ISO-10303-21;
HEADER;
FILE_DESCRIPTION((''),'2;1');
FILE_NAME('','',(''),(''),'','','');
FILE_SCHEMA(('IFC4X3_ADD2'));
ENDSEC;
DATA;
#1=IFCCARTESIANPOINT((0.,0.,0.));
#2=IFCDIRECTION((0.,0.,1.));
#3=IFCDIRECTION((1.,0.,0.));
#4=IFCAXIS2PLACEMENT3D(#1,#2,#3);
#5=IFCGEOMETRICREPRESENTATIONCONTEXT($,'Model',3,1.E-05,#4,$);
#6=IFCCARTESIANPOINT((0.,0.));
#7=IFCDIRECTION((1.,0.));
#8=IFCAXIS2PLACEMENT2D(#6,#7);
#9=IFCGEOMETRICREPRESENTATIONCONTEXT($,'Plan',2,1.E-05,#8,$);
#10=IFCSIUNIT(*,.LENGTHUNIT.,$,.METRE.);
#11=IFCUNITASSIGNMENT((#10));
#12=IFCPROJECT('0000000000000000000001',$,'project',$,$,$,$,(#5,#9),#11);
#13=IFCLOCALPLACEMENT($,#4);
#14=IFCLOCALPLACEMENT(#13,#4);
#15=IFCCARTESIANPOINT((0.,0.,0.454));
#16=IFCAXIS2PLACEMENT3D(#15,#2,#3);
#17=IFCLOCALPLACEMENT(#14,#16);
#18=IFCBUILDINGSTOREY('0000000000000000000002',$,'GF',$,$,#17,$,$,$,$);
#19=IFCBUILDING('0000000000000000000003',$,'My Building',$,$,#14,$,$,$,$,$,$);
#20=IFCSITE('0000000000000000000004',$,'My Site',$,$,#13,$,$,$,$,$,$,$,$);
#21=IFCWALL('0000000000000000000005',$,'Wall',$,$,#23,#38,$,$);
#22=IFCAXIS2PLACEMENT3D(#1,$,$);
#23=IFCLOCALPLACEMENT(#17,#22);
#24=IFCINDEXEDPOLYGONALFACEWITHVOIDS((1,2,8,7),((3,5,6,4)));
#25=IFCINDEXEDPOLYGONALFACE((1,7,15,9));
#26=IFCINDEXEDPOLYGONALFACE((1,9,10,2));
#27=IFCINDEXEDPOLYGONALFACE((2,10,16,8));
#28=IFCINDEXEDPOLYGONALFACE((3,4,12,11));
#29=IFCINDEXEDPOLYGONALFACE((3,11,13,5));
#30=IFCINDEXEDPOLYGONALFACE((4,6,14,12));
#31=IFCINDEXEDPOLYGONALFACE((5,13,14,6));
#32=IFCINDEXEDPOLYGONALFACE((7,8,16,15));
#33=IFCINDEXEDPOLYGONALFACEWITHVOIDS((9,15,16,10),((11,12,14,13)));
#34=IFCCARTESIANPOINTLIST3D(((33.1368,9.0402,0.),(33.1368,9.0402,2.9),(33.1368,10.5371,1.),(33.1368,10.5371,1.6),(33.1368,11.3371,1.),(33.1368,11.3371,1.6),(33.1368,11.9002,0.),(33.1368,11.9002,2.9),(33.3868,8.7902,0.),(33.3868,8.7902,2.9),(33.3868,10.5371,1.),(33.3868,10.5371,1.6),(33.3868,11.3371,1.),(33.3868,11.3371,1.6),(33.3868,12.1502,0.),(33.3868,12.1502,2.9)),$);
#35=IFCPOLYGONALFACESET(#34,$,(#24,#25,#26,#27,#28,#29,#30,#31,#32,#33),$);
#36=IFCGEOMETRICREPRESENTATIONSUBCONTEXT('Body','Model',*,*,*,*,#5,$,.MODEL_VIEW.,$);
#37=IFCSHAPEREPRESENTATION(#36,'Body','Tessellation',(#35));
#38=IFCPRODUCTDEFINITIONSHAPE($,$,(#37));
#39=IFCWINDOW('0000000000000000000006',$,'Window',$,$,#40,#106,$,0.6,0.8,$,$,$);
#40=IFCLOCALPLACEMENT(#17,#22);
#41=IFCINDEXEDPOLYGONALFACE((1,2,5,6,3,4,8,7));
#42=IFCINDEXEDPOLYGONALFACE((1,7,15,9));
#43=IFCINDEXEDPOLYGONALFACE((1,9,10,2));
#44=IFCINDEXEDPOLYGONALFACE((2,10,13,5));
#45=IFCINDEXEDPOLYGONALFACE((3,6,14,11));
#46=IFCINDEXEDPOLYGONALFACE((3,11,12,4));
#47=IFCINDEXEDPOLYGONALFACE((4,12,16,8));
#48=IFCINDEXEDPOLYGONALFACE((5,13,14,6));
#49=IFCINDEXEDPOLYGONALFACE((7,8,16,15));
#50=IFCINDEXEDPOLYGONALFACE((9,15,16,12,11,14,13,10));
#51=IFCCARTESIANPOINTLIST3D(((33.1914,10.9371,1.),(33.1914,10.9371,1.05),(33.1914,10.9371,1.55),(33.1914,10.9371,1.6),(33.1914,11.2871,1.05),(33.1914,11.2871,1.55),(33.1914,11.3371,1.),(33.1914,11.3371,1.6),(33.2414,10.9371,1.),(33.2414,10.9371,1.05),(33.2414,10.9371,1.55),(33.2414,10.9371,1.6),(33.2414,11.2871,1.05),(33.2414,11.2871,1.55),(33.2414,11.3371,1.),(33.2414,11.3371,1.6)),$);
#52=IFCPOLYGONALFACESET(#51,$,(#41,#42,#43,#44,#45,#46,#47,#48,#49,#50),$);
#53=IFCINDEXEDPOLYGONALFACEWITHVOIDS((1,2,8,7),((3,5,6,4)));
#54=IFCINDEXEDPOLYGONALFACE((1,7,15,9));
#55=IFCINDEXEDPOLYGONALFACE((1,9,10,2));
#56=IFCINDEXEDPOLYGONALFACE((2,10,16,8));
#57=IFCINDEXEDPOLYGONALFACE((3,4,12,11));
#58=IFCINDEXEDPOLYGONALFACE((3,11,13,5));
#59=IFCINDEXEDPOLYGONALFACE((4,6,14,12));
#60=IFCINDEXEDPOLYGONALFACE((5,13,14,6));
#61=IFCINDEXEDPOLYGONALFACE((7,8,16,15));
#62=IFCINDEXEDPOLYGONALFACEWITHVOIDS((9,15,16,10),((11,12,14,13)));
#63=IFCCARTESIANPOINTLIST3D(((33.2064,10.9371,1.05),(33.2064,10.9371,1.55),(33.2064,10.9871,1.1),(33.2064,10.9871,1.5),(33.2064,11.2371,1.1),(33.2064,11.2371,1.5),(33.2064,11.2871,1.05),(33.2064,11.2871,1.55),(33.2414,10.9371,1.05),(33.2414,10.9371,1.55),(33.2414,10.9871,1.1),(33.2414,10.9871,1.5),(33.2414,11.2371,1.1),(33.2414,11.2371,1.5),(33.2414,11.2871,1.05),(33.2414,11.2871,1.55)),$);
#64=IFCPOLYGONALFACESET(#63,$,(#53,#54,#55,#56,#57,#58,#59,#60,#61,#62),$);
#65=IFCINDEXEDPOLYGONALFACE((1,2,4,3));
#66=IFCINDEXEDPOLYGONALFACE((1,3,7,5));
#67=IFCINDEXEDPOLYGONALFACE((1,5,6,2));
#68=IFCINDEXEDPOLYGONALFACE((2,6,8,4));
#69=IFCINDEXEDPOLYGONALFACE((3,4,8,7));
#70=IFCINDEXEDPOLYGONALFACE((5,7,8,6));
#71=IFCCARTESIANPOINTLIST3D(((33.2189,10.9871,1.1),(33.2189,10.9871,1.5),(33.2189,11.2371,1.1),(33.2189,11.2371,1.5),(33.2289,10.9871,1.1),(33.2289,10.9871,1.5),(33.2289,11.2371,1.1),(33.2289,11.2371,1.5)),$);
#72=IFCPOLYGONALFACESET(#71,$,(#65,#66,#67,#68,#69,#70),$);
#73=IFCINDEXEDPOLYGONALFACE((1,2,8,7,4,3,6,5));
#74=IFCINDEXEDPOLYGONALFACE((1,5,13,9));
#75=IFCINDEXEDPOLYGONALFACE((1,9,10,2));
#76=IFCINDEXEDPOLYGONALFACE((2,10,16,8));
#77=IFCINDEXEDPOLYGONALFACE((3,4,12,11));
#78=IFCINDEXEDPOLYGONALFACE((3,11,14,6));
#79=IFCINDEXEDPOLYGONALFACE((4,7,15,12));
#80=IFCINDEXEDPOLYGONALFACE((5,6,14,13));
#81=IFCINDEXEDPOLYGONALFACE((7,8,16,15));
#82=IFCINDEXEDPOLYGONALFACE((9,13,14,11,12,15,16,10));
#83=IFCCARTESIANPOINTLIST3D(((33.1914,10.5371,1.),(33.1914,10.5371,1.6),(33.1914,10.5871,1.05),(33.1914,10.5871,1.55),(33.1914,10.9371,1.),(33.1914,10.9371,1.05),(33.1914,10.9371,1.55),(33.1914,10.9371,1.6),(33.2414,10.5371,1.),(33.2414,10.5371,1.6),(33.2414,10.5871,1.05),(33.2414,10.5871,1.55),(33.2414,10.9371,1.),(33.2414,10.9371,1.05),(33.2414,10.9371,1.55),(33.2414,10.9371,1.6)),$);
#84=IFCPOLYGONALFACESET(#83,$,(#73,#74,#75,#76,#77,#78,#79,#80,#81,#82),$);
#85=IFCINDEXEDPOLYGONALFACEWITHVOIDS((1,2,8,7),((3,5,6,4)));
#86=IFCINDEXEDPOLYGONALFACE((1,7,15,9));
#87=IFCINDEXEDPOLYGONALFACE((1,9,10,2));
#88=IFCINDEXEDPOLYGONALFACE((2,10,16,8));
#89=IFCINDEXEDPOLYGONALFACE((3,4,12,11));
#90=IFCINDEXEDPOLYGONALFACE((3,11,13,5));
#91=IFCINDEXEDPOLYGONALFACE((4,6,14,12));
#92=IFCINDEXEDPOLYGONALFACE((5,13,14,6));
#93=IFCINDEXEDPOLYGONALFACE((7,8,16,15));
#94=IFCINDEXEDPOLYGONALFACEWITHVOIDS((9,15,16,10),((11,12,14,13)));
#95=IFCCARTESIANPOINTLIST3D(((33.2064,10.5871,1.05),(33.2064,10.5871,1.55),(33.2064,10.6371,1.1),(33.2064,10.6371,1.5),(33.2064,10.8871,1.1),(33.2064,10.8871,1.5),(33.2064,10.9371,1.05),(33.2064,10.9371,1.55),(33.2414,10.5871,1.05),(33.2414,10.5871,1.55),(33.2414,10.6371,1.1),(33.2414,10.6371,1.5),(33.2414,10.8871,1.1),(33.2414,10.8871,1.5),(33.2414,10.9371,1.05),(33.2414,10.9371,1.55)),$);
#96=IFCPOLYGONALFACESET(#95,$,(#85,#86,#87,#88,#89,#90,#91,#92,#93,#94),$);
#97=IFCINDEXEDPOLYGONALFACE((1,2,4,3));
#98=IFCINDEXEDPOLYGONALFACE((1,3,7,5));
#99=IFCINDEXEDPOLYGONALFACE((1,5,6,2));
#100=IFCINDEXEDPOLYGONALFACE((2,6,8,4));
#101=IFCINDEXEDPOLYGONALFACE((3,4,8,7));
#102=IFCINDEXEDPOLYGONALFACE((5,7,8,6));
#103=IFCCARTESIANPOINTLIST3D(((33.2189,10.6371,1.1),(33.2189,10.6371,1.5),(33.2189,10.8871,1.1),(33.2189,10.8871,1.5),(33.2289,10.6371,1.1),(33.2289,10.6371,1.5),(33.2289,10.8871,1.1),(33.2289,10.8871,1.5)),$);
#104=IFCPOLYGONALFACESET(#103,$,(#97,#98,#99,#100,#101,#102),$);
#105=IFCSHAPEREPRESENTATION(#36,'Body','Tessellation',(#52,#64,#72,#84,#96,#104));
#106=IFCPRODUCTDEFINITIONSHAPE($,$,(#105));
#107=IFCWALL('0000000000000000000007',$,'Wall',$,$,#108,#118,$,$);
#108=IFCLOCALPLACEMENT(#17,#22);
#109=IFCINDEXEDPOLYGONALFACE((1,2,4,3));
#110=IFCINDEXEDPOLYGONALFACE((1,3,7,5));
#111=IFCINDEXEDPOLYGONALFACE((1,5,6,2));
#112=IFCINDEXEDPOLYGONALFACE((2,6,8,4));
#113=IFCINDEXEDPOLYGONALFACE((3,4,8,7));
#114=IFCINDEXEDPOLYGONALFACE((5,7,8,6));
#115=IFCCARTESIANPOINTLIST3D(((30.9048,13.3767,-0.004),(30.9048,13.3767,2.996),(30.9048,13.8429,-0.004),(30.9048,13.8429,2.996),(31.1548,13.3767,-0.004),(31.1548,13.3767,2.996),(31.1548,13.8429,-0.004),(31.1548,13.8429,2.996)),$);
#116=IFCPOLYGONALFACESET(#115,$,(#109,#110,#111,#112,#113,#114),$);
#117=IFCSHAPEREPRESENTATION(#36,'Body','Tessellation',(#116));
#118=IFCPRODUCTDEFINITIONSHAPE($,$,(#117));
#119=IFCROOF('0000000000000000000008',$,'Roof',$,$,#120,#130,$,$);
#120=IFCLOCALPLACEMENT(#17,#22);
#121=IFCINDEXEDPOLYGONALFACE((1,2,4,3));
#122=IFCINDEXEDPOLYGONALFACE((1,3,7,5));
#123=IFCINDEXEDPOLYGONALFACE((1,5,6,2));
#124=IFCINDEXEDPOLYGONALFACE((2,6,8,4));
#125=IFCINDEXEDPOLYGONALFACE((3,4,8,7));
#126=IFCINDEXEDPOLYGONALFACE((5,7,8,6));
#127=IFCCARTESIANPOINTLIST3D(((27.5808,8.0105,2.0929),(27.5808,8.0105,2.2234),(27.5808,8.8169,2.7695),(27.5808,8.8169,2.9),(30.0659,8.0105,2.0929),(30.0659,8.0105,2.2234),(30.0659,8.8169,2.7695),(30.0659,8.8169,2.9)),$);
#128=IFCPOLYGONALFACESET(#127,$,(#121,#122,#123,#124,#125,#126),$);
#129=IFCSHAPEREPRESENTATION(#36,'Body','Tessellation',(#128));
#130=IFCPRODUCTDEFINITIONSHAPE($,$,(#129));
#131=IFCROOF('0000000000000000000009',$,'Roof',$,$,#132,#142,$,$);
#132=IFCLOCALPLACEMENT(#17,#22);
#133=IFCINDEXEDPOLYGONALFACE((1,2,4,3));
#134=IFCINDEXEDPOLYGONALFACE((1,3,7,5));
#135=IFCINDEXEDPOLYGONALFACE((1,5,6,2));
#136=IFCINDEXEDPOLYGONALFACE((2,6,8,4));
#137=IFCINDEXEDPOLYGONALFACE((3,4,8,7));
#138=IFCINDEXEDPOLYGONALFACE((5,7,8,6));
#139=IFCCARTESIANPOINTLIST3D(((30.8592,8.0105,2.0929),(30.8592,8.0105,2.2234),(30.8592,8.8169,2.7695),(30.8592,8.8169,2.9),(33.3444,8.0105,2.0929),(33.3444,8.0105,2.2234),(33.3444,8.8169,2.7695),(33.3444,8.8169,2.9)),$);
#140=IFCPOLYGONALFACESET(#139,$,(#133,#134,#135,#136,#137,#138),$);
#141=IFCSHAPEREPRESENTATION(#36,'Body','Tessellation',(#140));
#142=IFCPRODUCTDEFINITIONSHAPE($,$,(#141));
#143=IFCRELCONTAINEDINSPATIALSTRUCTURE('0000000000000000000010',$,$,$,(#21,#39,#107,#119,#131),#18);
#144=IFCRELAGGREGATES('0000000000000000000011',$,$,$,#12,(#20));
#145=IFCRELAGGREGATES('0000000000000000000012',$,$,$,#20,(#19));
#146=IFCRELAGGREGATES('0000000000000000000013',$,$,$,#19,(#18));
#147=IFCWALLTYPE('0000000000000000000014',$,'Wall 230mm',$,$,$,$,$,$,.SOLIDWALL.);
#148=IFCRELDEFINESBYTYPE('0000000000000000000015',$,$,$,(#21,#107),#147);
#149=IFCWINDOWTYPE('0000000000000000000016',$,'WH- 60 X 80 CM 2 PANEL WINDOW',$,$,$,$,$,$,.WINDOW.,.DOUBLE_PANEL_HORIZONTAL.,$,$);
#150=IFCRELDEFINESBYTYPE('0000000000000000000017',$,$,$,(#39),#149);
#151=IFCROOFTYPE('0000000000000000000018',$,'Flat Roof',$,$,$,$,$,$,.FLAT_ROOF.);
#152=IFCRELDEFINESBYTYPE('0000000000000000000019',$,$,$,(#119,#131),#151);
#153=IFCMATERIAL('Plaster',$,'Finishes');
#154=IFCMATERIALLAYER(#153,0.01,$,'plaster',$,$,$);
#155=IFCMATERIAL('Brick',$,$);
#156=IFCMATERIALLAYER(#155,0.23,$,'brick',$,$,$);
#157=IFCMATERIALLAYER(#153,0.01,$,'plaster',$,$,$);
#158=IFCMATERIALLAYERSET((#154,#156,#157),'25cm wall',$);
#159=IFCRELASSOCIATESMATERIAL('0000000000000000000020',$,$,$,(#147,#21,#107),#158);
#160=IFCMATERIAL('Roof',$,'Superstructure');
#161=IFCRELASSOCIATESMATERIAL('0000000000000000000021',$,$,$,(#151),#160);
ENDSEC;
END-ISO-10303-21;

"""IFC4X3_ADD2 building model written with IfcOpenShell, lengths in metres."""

from ifc_helpers import new_model, entity, si_unit, frame, origin_with_axes, origin_2d_with_axis, place, context, subcontext, project, spatial, polyline, line, indexed_curve, outline, extrude, shape, source, transform, mapped, material, layer, layer_set, layer_usage, type_object, type_shapes, element, fill, save


model = new_model("IFC4X3_ADD2")

# Units and contexts
model_context = context("Model", 3, precision=1e-05, world=origin_with_axes())
plan_context = context("Plan", 2, precision=1e-05, world=origin_2d_with_axis())
body_context_1 = subcontext(model_context, "Body", "Model", "MODEL_VIEW")
body_context_2 = subcontext(plan_context, "Body", "Plan", "PLAN_VIEW")
ifc_project = project(units=[si_unit("LENGTHUNIT", "METRE")], contexts=[model_context, plan_context])

# Site, building, storey
site_placement = place(None, origin_with_axes())
site = spatial("IfcSite", under=ifc_project, at=site_placement, Name="My Site")
building_placement = place(site_placement, origin_with_axes())
building = spatial("IfcBuilding", under=site, at=building_placement, Name="My Building")
storey_placement = place(building_placement, frame((0.0, 0.0, 0.454), z_axis=(0.0, 0.0, 1.0), x_axis=(1.0, 0.0, 0.0)))
storey = spatial("IfcBuildingStorey", under=building, at=storey_placement, Name="GF")

# Shared definitions
ifc_material_1 = material(Name="Plaster", Category="Finishes")
ifc_layer_1 = layer(ifc_material_1, 0.01, Name="plaster")
ifc_material_2 = material(Name="Brick")
ifc_layer_2 = layer(ifc_material_2, 0.23, Name="brick")
ifc_layer_3 = layer(ifc_material_1, 0.01, Name="plaster")
ifc_layer_set_1 = layer_set([ifc_layer_1, ifc_layer_2, ifc_layer_3], Name="25cm wall")
wall_type_1 = type_object("IfcWallType", Name="Wall 230mm", PredefinedType="SOLIDWALL", material=ifc_layer_set_1)

# Wall, opening, window
ifc_layer_usage_1 = layer_usage(ifc_layer_set_1, "AXIS2", "POSITIVE", 0.0)
wall_1_placement = place(storey_placement, frame((33.3868, 8.7902, 0.0), z_axis=(0.0, 0.0, 1.0), x_axis=(0.000001, 1.0, 0.0)))
wall_1 = element("IfcWall", 1, at=wall_1_placement, inside=storey, type_object=wall_type_1, material=ifc_layer_usage_1, Name="Wall", context=body_context_1, shape_type="SweptSolid", body=[
    extrude(outline(indexed_curve([(0.0, 0.0), (0.25, 0.25), (3.11, 0.25), (3.36, 0.0)], segments=[line(1, 2, 3, 4, 1)])), origin_with_axes(), (0.0, 0.0, 1.0), 2.9),
])
shared_shape_1 = source(origin_with_axes(), body_context_1, "Body", "SweptSolid", [
    extrude(outline(indexed_curve([(0.0, 0.0), (0.8, 0.0), (0.8, 0.6), (0.0, 0.6)], segments=[line(1, 2, 3, 4, 1)])), frame((0.0, -0.6, 0.0), z_axis=(0.0, -1.0, 0.0), x_axis=(1.0, 0.0, 0.0)), (0.0, 0.0, -1.0), 1.2),
])
opening_1_placement = place(wall_1_placement, frame((2.5469, 0.1953, 1.0), z_axis=(0.0, 0.0, 1.0), x_axis=(-1.0, 0.0, 0.0)))
opening_1 = element("IfcOpeningElement", 2, at=opening_1_placement, cuts=wall_1, PredefinedType="OPENING", context=body_context_1, shape_type="MappedRepresentation", body=[
    mapped(shared_shape_1, transform((0.0, 0.0, 0.0), x_axis=(1.0, 0.0, 0.0), y_axis=(0.0, 1.0, 0.0), z_axis=(0.0, 0.0, 1.0), scale=1.0)),
])
window_type = type_object("IfcWindowType", Name="WH- 60 X 80 CM 2 PANEL WINDOW", PartitioningType="DOUBLE_PANEL_HORIZONTAL", PredefinedType="WINDOW")
shared_shape_2 = source(origin_with_axes(), body_context_1, "Body", "SweptSolid", [
    extrude(outline(indexed_curve([(0.4, 0.0), (0.0, 0.0), (0.0, 0.6), (0.4, 0.6), (0.4, 0.55), (0.05, 0.55), (0.05, 0.05), (0.4, 0.05)], segments=[line(1, 2, 3, 4, 5, 6, 7, 8, 1)])), frame((0.0, 0.0, 0.0), z_axis=(0.0, -1.0, 0.0), x_axis=(1.0, 0.0, 0.0)), (0.0, 0.0, -1.0), 0.05),
    extrude(outline(indexed_curve([(0.0, 0.0), (0.35, 0.0), (0.35, 0.5), (0.0, 0.5)], segments=[line(1, 2, 3, 4, 1)]), holes=[indexed_curve([(0.05, 0.05), (0.3, 0.05), (0.3, 0.45), (0.05, 0.45)], segments=[line(1, 2, 3, 4, 1)])]), frame((0.05, 0.015, 0.05), z_axis=(0.0, -1.0, 0.0), x_axis=(1.0, 0.0, 0.0)), (0.0, 0.0, -1.0), 0.035),
    extrude(outline(indexed_curve([(0.05, 0.05), (0.3, 0.05), (0.3, 0.45), (0.05, 0.45)], segments=[line(1, 2, 3, 4, 1)])), frame((0.05, 0.0275, 0.05), z_axis=(0.0, -1.0, 0.0), x_axis=(1.0, 0.0, 0.0)), (0.0, 0.0, -1.0), 0.01),
    extrude(outline(indexed_curve([(0.0, 0.6), (0.4, 0.6), (0.4, 0.0), (0.0, 0.0), (0.0, 0.05), (0.35, 0.05), (0.35, 0.55), (0.0, 0.55)], segments=[line(1, 2, 3, 4, 5, 6, 7, 8, 1)])), frame((0.4, 0.0, 0.0), z_axis=(0.0, -1.0, 0.0), x_axis=(1.0, 0.0, 0.0)), (0.0, 0.0, -1.0), 0.05),
    extrude(outline(indexed_curve([(0.0, 0.0), (0.35, 0.0), (0.35, 0.5), (0.0, 0.5)], segments=[line(1, 2, 3, 4, 1)]), holes=[indexed_curve([(0.05, 0.05), (0.3, 0.05), (0.3, 0.45), (0.05, 0.45)], segments=[line(1, 2, 3, 4, 1)])]), frame((0.4, 0.015, 0.05), z_axis=(0.0, -1.0, 0.0), x_axis=(1.0, 0.0, 0.0)), (0.0, 0.0, -1.0), 0.035),
    extrude(outline(indexed_curve([(0.05, 0.05), (0.3, 0.05), (0.3, 0.45), (0.05, 0.45)], segments=[line(1, 2, 3, 4, 1)])), frame((0.4, 0.0275, 0.05), z_axis=(0.0, -1.0, 0.0), x_axis=(1.0, 0.0, 0.0)), (0.0, 0.0, -1.0), 0.01),
])
shared_shape_3 = source(origin_with_axes(), body_context_2, "Body", "Curve2D", [
    entity("IfcIndexedPolyCurve", entity("IfcCartesianPointList2D", [[0.05, 0.0], [0.4, 0.0]])),
    entity("IfcIndexedPolyCurve", entity("IfcCartesianPointList2D", [[0.0, 0.05], [0.05, 0.05], [0.05, 0.0], [0.0, 0.0]]), [entity("IfcLineIndex", [1, 2, 3, 4, 1])]),
    entity("IfcIndexedPolyCurve", entity("IfcCartesianPointList2D", [[0.4, 0.05], [0.4, 0.05], [0.4, 0.0], [0.4, 0.0]])),
    entity("IfcIndexedPolyCurve", entity("IfcCartesianPointList2D", [[0.05, 0.015], [0.1, 0.015], [0.1, 0.05], [0.05, 0.05]]), [entity("IfcLineIndex", [1, 2, 3, 4, 1])]),
    entity("IfcIndexedPolyCurve", entity("IfcCartesianPointList2D", [[0.4, 0.015], [0.35, 0.015], [0.35, 0.05], [0.4, 0.05]]), [entity("IfcLineIndex", [1, 2, 3, 4, 1])]),
    entity("IfcIndexedPolyCurve", entity("IfcCartesianPointList2D", [[0.1, 0.015], [0.35, 0.015]])),
    entity("IfcIndexedPolyCurve", entity("IfcCartesianPointList2D", [[0.1, 0.05], [0.35, 0.05]])),
    entity("IfcIndexedPolyCurve", entity("IfcCartesianPointList2D", [[0.1, 0.0325], [0.35, 0.0325]])),
    entity("IfcIndexedPolyCurve", entity("IfcCartesianPointList2D", [[0.4, 0.0], [0.75, 0.0]])),
    entity("IfcIndexedPolyCurve", entity("IfcCartesianPointList2D", [[0.4, 0.05], [0.4, 0.05], [0.4, 0.0], [0.4, 0.0]])),
    entity("IfcIndexedPolyCurve", entity("IfcCartesianPointList2D", [[0.8, 0.05], [0.75, 0.05], [0.75, 0.0], [0.8, 0.0]]), [entity("IfcLineIndex", [1, 2, 3, 4, 1])]),
    entity("IfcIndexedPolyCurve", entity("IfcCartesianPointList2D", [[0.4, 0.015], [0.45, 0.015], [0.45, 0.05], [0.4, 0.05]]), [entity("IfcLineIndex", [1, 2, 3, 4, 1])]),
    entity("IfcIndexedPolyCurve", entity("IfcCartesianPointList2D", [[0.75, 0.015], [0.7, 0.015], [0.7, 0.05], [0.75, 0.05]]), [entity("IfcLineIndex", [1, 2, 3, 4, 1])]),
    entity("IfcIndexedPolyCurve", entity("IfcCartesianPointList2D", [[0.45, 0.015], [0.7, 0.015]])),
    entity("IfcIndexedPolyCurve", entity("IfcCartesianPointList2D", [[0.45, 0.05], [0.7, 0.05]])),
    entity("IfcIndexedPolyCurve", entity("IfcCartesianPointList2D", [[0.45, 0.0325], [0.7, 0.0325]])),
])
type_shapes(window_type, [shared_shape_2, shared_shape_3])
window_placement = place(opening_1_placement, frame((0.0, 0.0, 0.0), z_axis=(0.0, 0.0, 1.0), x_axis=(1.0, 0.0, 0.0)))
window = element("IfcWindow", 3, at=window_placement, inside=storey, type_object=window_type, Name="Window", OverallHeight=0.6, OverallWidth=0.8, shapes=[
    shape(body_context_1, "Body", "MappedRepresentation", [mapped(shared_shape_2, transform((0.0, 0.0, 0.0), x_axis=(1.0, 0.0, 0.0), y_axis=(0.0, 1.0, 0.0), z_axis=(0.0, 0.0, 1.0), scale=1.0))]),
    shape(body_context_2, "Body", "MappedRepresentation", [mapped(shared_shape_3, transform((0.0, 0.0, 0.0), x_axis=(1.0, 0.0, 0.0), y_axis=(0.0, 1.0, 0.0), z_axis=(0.0, 0.0, 1.0), scale=1.0))]),
])
fill(opening_1, window)

# Wall
ifc_layer_usage_2 = layer_usage(ifc_layer_set_1, "AXIS2", "POSITIVE", 0.0)
wall_2_placement = place(storey_placement, frame((31.1548, 13.3767, -0.004), z_axis=(0.0, 0.0, 1.0), x_axis=(0.000001, 1.0, 0.0)))
element("IfcWall", 4, at=wall_2_placement, inside=storey, type_object=wall_type_1, material=ifc_layer_usage_2, Name="Wall", context=body_context_1, shape_type="SweptSolid", body=[
    extrude(outline(indexed_curve([(0.0, 0.0), (0.0, 0.25), (0.4662, 0.25), (0.4662, 0.0)], segments=[line(1, 2, 3, 4, 1)])), origin_with_axes(), (0.0, 0.0, 1.0), 3.0),
])

# Roofs
ifc_material_3 = material(Name="Roof", Category="Superstructure")
roof_type = type_object("IfcRoofType", Name="Flat Roof", PredefinedType="FLAT_ROOF", material=ifc_material_3)
for number, where, z_axis, x_axis, name in (
    (5, (27.5808, 8.0241, 2.1043), (0.0, -0.642788, 0.766044), (1.0, 0.0, 0.0), "Roof"),
    (6, (30.8592, 8.0241, 2.1043), (0.0, -0.642788, 0.766044), (1.0, 0.0, 0.0), "Roof"),
):
    element("IfcRoof", number, at=place(storey_placement, frame(where, z_axis=z_axis, x_axis=x_axis)), inside=storey, type_object=roof_type, Name=name, context=body_context_1, shape_type="SweptSolid", body=[
        extrude(outline(polyline([(-1.2426, -0.0653), (1.2426, -0.0653), (1.2426, 0.0653), (-1.2426, 0.0653), (-1.2426, -0.0653)])), frame((1.2426, 1.0768, 0.05), z_axis=(0.0, 0.766044, -0.642788), x_axis=(1.0, 0.0, 0.0)), (0.0, 0.642788, -0.766044), 1.0526),
    ])

save(model, "model.ifc")
